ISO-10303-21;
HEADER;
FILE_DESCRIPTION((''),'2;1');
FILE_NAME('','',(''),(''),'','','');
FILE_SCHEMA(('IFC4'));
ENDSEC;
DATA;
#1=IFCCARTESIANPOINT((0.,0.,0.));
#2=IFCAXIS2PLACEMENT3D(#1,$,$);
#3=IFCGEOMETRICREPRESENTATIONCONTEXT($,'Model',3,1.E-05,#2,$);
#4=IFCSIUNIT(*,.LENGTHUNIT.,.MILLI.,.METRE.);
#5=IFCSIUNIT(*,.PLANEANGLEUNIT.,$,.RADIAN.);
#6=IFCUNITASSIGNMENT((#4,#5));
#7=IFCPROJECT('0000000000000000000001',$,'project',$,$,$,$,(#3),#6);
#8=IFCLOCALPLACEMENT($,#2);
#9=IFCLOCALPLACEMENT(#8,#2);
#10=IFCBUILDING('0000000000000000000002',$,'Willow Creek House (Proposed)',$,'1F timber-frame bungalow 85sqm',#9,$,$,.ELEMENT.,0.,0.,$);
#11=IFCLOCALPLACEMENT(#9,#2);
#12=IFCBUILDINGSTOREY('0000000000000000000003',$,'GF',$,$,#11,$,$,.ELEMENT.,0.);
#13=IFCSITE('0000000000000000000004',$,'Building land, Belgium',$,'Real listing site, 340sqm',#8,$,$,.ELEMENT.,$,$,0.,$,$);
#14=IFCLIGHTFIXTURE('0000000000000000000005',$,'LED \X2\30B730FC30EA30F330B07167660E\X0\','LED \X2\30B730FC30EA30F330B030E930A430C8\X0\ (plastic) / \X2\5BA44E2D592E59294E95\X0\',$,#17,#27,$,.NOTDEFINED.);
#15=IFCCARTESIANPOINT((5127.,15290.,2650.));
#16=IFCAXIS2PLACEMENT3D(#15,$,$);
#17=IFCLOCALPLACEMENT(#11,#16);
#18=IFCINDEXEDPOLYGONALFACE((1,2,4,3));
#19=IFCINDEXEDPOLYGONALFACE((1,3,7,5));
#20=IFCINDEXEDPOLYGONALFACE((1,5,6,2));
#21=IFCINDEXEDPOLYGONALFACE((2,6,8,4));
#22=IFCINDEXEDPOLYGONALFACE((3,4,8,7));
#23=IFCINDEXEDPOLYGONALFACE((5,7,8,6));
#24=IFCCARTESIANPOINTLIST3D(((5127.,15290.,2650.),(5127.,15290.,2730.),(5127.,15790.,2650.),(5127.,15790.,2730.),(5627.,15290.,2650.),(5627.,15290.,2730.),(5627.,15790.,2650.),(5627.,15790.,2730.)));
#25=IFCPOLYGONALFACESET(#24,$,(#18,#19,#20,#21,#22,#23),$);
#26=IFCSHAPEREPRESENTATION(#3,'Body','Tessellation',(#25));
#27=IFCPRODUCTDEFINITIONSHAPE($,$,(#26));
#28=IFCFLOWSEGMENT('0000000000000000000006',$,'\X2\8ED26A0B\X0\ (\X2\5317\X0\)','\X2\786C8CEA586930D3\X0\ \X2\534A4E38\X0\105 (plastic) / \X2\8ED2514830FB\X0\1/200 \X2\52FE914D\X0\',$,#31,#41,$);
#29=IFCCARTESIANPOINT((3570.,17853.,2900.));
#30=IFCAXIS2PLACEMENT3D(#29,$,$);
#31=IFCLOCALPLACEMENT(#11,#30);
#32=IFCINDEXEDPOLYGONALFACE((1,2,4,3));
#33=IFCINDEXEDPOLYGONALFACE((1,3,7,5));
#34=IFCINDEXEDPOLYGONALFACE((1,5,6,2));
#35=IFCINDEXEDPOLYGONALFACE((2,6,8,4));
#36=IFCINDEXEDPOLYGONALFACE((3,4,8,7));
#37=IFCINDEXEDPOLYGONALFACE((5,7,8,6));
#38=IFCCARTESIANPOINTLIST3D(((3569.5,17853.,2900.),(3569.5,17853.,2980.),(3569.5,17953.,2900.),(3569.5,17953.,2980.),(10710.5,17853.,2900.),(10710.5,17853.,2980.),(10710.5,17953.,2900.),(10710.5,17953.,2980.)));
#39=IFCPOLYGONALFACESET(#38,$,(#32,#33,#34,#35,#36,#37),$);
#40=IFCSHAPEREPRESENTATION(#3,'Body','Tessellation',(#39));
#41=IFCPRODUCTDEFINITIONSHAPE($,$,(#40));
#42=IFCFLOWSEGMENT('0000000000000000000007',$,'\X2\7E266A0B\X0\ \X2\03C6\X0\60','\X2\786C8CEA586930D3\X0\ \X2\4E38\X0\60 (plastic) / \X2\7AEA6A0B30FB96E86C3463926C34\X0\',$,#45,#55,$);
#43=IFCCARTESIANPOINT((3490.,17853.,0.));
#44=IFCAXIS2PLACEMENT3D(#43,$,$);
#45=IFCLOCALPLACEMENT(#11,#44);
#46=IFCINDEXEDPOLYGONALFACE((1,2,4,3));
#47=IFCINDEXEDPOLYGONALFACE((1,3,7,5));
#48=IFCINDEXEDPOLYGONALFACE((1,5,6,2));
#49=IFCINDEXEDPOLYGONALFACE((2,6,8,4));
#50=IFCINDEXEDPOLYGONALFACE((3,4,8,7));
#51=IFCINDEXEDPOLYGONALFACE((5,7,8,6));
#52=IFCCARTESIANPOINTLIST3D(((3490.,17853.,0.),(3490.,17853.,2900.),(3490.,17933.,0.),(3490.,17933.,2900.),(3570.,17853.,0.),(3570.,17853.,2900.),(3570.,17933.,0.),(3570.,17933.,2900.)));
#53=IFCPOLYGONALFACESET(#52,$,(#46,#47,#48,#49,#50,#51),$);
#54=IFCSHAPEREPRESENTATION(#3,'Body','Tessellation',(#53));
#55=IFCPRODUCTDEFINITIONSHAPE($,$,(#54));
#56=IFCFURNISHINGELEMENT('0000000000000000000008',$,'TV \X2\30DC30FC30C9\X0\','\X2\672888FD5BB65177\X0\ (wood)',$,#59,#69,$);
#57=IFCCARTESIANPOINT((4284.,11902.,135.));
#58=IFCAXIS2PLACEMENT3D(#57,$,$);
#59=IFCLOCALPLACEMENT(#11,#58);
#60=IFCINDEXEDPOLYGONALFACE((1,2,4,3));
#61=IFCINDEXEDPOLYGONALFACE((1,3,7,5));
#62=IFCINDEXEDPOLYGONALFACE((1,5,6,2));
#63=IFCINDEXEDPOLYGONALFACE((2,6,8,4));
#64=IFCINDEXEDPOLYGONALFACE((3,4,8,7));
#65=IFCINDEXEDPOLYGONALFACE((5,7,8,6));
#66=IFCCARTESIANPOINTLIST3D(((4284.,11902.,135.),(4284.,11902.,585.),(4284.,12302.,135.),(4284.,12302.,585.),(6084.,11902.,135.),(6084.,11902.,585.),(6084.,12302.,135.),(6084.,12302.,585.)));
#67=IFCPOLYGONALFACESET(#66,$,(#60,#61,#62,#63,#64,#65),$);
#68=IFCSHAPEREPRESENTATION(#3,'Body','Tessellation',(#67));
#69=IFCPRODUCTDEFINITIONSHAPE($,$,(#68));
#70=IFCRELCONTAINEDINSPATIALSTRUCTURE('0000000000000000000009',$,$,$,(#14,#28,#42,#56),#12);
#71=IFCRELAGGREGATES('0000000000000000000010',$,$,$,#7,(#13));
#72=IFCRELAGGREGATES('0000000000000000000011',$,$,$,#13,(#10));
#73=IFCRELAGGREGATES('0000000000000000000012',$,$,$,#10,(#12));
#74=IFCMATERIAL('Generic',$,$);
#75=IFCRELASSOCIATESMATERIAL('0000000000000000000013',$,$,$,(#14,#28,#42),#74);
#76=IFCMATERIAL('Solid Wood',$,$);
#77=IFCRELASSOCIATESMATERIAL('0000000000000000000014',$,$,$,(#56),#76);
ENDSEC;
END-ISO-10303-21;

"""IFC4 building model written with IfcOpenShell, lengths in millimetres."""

from ifc_helpers import new_model, si_unit, frame, frame_2d, origin, place, context, project, spatial, rectangle, extrude, material, element, save


model = new_model("IFC4")

# Units and contexts
model_context = context("Model", 3, precision=1e-05, world=origin())
ifc_project = project(units=[si_unit("LENGTHUNIT", "METRE", prefix="MILLI"), si_unit("PLANEANGLEUNIT", "RADIAN")], contexts=[model_context])

# Site, building, storey
site_placement = place(None, origin())
site = spatial("IfcSite", under=ifc_project, at=site_placement, Name="Building land, Belgium", ObjectType="Real listing site, 340sqm", CompositionType="ELEMENT", RefElevation=0.0)
building_placement = place(site_placement, origin())
building = spatial("IfcBuilding", under=site, at=building_placement, Name="Willow Creek House (Proposed)", ObjectType="1F timber-frame bungalow 85sqm", CompositionType="ELEMENT", ElevationOfRefHeight=0.0, ElevationOfTerrain=0.0)
storey_placement = place(building_placement, origin())
storey = spatial("IfcBuildingStorey", under=building, at=storey_placement, Name="GF", CompositionType="ELEMENT", Elevation=0.0)

# Shared definitions
ifc_material_1 = material(Name="Solid Wood")

# Shared definitions
ifc_material_2 = material(Name="Generic")

# Light fixture
light_fixture_placement = place(storey_placement, frame((5127.0, 15290.0, 2650.0)))
element("IfcLightFixture", 1, at=light_fixture_placement, inside=storey, material=ifc_material_2, Name="LED シーリング照明", Description="LED シーリングライト (plastic) / 室中央天井", PredefinedType="NOTDEFINED", context=model_context, shape_type="SweptSolid", body=[
    extrude(rectangle(XDim=500.0, YDim=500.0, at=frame_2d((250.0, 250.0))), frame((5127.0, 15290.0, 2650.0)), (0.0, 0.0, 1.0), 80.0),
])

# Flow segments
flow_segment_1_placement = place(storey_placement, frame((3570.0, 17853.0, 2900.0)))
element("IfcFlowSegment", 2, at=flow_segment_1_placement, inside=storey, material=ifc_material_2, Name="軒樋 (北)", Description="硬質塩ビ 半丸105 (plastic) / 軒先・1/200 勾配", context=model_context, shape_type="SweptSolid", body=[
    extrude(rectangle(XDim=7141.0, YDim=100.0, at=frame_2d((3570.0, 50.0))), frame((3570.0, 17853.0, 2900.0)), (0.0, 0.0, 1.0), 80.0),
])
flow_segment_2_placement = place(storey_placement, frame((3490.0, 17853.0, 0.0)))
element("IfcFlowSegment", 3, at=flow_segment_2_placement, inside=storey, material=ifc_material_2, Name="縦樋 φ60", Description="硬質塩ビ 丸60 (plastic) / 竪樋・雨水排水", context=model_context, shape_type="SweptSolid", body=[
    extrude(rectangle(XDim=80.0, YDim=80.0, at=frame_2d((40.0, 40.0))), frame((3490.0, 17853.0, 0.0)), (0.0, 0.0, 1.0), 2900.0),
])

# Furnishing element
furnishing_placement = place(storey_placement, frame((4284.0, 11902.0, 135.0)))
element("IfcFurnishingElement", 4, at=furnishing_placement, inside=storey, material=ifc_material_1, Name="TV ボード", Description="木製家具 (wood)", context=model_context, shape_type="SweptSolid", body=[
    extrude(rectangle(XDim=1800.0, YDim=400.0, at=frame_2d((900.0, 200.0))), frame((4284.0, 11902.0, 135.0)), (0.0, 0.0, 1.0), 450.0),
])

save(model, "model.ifc")
